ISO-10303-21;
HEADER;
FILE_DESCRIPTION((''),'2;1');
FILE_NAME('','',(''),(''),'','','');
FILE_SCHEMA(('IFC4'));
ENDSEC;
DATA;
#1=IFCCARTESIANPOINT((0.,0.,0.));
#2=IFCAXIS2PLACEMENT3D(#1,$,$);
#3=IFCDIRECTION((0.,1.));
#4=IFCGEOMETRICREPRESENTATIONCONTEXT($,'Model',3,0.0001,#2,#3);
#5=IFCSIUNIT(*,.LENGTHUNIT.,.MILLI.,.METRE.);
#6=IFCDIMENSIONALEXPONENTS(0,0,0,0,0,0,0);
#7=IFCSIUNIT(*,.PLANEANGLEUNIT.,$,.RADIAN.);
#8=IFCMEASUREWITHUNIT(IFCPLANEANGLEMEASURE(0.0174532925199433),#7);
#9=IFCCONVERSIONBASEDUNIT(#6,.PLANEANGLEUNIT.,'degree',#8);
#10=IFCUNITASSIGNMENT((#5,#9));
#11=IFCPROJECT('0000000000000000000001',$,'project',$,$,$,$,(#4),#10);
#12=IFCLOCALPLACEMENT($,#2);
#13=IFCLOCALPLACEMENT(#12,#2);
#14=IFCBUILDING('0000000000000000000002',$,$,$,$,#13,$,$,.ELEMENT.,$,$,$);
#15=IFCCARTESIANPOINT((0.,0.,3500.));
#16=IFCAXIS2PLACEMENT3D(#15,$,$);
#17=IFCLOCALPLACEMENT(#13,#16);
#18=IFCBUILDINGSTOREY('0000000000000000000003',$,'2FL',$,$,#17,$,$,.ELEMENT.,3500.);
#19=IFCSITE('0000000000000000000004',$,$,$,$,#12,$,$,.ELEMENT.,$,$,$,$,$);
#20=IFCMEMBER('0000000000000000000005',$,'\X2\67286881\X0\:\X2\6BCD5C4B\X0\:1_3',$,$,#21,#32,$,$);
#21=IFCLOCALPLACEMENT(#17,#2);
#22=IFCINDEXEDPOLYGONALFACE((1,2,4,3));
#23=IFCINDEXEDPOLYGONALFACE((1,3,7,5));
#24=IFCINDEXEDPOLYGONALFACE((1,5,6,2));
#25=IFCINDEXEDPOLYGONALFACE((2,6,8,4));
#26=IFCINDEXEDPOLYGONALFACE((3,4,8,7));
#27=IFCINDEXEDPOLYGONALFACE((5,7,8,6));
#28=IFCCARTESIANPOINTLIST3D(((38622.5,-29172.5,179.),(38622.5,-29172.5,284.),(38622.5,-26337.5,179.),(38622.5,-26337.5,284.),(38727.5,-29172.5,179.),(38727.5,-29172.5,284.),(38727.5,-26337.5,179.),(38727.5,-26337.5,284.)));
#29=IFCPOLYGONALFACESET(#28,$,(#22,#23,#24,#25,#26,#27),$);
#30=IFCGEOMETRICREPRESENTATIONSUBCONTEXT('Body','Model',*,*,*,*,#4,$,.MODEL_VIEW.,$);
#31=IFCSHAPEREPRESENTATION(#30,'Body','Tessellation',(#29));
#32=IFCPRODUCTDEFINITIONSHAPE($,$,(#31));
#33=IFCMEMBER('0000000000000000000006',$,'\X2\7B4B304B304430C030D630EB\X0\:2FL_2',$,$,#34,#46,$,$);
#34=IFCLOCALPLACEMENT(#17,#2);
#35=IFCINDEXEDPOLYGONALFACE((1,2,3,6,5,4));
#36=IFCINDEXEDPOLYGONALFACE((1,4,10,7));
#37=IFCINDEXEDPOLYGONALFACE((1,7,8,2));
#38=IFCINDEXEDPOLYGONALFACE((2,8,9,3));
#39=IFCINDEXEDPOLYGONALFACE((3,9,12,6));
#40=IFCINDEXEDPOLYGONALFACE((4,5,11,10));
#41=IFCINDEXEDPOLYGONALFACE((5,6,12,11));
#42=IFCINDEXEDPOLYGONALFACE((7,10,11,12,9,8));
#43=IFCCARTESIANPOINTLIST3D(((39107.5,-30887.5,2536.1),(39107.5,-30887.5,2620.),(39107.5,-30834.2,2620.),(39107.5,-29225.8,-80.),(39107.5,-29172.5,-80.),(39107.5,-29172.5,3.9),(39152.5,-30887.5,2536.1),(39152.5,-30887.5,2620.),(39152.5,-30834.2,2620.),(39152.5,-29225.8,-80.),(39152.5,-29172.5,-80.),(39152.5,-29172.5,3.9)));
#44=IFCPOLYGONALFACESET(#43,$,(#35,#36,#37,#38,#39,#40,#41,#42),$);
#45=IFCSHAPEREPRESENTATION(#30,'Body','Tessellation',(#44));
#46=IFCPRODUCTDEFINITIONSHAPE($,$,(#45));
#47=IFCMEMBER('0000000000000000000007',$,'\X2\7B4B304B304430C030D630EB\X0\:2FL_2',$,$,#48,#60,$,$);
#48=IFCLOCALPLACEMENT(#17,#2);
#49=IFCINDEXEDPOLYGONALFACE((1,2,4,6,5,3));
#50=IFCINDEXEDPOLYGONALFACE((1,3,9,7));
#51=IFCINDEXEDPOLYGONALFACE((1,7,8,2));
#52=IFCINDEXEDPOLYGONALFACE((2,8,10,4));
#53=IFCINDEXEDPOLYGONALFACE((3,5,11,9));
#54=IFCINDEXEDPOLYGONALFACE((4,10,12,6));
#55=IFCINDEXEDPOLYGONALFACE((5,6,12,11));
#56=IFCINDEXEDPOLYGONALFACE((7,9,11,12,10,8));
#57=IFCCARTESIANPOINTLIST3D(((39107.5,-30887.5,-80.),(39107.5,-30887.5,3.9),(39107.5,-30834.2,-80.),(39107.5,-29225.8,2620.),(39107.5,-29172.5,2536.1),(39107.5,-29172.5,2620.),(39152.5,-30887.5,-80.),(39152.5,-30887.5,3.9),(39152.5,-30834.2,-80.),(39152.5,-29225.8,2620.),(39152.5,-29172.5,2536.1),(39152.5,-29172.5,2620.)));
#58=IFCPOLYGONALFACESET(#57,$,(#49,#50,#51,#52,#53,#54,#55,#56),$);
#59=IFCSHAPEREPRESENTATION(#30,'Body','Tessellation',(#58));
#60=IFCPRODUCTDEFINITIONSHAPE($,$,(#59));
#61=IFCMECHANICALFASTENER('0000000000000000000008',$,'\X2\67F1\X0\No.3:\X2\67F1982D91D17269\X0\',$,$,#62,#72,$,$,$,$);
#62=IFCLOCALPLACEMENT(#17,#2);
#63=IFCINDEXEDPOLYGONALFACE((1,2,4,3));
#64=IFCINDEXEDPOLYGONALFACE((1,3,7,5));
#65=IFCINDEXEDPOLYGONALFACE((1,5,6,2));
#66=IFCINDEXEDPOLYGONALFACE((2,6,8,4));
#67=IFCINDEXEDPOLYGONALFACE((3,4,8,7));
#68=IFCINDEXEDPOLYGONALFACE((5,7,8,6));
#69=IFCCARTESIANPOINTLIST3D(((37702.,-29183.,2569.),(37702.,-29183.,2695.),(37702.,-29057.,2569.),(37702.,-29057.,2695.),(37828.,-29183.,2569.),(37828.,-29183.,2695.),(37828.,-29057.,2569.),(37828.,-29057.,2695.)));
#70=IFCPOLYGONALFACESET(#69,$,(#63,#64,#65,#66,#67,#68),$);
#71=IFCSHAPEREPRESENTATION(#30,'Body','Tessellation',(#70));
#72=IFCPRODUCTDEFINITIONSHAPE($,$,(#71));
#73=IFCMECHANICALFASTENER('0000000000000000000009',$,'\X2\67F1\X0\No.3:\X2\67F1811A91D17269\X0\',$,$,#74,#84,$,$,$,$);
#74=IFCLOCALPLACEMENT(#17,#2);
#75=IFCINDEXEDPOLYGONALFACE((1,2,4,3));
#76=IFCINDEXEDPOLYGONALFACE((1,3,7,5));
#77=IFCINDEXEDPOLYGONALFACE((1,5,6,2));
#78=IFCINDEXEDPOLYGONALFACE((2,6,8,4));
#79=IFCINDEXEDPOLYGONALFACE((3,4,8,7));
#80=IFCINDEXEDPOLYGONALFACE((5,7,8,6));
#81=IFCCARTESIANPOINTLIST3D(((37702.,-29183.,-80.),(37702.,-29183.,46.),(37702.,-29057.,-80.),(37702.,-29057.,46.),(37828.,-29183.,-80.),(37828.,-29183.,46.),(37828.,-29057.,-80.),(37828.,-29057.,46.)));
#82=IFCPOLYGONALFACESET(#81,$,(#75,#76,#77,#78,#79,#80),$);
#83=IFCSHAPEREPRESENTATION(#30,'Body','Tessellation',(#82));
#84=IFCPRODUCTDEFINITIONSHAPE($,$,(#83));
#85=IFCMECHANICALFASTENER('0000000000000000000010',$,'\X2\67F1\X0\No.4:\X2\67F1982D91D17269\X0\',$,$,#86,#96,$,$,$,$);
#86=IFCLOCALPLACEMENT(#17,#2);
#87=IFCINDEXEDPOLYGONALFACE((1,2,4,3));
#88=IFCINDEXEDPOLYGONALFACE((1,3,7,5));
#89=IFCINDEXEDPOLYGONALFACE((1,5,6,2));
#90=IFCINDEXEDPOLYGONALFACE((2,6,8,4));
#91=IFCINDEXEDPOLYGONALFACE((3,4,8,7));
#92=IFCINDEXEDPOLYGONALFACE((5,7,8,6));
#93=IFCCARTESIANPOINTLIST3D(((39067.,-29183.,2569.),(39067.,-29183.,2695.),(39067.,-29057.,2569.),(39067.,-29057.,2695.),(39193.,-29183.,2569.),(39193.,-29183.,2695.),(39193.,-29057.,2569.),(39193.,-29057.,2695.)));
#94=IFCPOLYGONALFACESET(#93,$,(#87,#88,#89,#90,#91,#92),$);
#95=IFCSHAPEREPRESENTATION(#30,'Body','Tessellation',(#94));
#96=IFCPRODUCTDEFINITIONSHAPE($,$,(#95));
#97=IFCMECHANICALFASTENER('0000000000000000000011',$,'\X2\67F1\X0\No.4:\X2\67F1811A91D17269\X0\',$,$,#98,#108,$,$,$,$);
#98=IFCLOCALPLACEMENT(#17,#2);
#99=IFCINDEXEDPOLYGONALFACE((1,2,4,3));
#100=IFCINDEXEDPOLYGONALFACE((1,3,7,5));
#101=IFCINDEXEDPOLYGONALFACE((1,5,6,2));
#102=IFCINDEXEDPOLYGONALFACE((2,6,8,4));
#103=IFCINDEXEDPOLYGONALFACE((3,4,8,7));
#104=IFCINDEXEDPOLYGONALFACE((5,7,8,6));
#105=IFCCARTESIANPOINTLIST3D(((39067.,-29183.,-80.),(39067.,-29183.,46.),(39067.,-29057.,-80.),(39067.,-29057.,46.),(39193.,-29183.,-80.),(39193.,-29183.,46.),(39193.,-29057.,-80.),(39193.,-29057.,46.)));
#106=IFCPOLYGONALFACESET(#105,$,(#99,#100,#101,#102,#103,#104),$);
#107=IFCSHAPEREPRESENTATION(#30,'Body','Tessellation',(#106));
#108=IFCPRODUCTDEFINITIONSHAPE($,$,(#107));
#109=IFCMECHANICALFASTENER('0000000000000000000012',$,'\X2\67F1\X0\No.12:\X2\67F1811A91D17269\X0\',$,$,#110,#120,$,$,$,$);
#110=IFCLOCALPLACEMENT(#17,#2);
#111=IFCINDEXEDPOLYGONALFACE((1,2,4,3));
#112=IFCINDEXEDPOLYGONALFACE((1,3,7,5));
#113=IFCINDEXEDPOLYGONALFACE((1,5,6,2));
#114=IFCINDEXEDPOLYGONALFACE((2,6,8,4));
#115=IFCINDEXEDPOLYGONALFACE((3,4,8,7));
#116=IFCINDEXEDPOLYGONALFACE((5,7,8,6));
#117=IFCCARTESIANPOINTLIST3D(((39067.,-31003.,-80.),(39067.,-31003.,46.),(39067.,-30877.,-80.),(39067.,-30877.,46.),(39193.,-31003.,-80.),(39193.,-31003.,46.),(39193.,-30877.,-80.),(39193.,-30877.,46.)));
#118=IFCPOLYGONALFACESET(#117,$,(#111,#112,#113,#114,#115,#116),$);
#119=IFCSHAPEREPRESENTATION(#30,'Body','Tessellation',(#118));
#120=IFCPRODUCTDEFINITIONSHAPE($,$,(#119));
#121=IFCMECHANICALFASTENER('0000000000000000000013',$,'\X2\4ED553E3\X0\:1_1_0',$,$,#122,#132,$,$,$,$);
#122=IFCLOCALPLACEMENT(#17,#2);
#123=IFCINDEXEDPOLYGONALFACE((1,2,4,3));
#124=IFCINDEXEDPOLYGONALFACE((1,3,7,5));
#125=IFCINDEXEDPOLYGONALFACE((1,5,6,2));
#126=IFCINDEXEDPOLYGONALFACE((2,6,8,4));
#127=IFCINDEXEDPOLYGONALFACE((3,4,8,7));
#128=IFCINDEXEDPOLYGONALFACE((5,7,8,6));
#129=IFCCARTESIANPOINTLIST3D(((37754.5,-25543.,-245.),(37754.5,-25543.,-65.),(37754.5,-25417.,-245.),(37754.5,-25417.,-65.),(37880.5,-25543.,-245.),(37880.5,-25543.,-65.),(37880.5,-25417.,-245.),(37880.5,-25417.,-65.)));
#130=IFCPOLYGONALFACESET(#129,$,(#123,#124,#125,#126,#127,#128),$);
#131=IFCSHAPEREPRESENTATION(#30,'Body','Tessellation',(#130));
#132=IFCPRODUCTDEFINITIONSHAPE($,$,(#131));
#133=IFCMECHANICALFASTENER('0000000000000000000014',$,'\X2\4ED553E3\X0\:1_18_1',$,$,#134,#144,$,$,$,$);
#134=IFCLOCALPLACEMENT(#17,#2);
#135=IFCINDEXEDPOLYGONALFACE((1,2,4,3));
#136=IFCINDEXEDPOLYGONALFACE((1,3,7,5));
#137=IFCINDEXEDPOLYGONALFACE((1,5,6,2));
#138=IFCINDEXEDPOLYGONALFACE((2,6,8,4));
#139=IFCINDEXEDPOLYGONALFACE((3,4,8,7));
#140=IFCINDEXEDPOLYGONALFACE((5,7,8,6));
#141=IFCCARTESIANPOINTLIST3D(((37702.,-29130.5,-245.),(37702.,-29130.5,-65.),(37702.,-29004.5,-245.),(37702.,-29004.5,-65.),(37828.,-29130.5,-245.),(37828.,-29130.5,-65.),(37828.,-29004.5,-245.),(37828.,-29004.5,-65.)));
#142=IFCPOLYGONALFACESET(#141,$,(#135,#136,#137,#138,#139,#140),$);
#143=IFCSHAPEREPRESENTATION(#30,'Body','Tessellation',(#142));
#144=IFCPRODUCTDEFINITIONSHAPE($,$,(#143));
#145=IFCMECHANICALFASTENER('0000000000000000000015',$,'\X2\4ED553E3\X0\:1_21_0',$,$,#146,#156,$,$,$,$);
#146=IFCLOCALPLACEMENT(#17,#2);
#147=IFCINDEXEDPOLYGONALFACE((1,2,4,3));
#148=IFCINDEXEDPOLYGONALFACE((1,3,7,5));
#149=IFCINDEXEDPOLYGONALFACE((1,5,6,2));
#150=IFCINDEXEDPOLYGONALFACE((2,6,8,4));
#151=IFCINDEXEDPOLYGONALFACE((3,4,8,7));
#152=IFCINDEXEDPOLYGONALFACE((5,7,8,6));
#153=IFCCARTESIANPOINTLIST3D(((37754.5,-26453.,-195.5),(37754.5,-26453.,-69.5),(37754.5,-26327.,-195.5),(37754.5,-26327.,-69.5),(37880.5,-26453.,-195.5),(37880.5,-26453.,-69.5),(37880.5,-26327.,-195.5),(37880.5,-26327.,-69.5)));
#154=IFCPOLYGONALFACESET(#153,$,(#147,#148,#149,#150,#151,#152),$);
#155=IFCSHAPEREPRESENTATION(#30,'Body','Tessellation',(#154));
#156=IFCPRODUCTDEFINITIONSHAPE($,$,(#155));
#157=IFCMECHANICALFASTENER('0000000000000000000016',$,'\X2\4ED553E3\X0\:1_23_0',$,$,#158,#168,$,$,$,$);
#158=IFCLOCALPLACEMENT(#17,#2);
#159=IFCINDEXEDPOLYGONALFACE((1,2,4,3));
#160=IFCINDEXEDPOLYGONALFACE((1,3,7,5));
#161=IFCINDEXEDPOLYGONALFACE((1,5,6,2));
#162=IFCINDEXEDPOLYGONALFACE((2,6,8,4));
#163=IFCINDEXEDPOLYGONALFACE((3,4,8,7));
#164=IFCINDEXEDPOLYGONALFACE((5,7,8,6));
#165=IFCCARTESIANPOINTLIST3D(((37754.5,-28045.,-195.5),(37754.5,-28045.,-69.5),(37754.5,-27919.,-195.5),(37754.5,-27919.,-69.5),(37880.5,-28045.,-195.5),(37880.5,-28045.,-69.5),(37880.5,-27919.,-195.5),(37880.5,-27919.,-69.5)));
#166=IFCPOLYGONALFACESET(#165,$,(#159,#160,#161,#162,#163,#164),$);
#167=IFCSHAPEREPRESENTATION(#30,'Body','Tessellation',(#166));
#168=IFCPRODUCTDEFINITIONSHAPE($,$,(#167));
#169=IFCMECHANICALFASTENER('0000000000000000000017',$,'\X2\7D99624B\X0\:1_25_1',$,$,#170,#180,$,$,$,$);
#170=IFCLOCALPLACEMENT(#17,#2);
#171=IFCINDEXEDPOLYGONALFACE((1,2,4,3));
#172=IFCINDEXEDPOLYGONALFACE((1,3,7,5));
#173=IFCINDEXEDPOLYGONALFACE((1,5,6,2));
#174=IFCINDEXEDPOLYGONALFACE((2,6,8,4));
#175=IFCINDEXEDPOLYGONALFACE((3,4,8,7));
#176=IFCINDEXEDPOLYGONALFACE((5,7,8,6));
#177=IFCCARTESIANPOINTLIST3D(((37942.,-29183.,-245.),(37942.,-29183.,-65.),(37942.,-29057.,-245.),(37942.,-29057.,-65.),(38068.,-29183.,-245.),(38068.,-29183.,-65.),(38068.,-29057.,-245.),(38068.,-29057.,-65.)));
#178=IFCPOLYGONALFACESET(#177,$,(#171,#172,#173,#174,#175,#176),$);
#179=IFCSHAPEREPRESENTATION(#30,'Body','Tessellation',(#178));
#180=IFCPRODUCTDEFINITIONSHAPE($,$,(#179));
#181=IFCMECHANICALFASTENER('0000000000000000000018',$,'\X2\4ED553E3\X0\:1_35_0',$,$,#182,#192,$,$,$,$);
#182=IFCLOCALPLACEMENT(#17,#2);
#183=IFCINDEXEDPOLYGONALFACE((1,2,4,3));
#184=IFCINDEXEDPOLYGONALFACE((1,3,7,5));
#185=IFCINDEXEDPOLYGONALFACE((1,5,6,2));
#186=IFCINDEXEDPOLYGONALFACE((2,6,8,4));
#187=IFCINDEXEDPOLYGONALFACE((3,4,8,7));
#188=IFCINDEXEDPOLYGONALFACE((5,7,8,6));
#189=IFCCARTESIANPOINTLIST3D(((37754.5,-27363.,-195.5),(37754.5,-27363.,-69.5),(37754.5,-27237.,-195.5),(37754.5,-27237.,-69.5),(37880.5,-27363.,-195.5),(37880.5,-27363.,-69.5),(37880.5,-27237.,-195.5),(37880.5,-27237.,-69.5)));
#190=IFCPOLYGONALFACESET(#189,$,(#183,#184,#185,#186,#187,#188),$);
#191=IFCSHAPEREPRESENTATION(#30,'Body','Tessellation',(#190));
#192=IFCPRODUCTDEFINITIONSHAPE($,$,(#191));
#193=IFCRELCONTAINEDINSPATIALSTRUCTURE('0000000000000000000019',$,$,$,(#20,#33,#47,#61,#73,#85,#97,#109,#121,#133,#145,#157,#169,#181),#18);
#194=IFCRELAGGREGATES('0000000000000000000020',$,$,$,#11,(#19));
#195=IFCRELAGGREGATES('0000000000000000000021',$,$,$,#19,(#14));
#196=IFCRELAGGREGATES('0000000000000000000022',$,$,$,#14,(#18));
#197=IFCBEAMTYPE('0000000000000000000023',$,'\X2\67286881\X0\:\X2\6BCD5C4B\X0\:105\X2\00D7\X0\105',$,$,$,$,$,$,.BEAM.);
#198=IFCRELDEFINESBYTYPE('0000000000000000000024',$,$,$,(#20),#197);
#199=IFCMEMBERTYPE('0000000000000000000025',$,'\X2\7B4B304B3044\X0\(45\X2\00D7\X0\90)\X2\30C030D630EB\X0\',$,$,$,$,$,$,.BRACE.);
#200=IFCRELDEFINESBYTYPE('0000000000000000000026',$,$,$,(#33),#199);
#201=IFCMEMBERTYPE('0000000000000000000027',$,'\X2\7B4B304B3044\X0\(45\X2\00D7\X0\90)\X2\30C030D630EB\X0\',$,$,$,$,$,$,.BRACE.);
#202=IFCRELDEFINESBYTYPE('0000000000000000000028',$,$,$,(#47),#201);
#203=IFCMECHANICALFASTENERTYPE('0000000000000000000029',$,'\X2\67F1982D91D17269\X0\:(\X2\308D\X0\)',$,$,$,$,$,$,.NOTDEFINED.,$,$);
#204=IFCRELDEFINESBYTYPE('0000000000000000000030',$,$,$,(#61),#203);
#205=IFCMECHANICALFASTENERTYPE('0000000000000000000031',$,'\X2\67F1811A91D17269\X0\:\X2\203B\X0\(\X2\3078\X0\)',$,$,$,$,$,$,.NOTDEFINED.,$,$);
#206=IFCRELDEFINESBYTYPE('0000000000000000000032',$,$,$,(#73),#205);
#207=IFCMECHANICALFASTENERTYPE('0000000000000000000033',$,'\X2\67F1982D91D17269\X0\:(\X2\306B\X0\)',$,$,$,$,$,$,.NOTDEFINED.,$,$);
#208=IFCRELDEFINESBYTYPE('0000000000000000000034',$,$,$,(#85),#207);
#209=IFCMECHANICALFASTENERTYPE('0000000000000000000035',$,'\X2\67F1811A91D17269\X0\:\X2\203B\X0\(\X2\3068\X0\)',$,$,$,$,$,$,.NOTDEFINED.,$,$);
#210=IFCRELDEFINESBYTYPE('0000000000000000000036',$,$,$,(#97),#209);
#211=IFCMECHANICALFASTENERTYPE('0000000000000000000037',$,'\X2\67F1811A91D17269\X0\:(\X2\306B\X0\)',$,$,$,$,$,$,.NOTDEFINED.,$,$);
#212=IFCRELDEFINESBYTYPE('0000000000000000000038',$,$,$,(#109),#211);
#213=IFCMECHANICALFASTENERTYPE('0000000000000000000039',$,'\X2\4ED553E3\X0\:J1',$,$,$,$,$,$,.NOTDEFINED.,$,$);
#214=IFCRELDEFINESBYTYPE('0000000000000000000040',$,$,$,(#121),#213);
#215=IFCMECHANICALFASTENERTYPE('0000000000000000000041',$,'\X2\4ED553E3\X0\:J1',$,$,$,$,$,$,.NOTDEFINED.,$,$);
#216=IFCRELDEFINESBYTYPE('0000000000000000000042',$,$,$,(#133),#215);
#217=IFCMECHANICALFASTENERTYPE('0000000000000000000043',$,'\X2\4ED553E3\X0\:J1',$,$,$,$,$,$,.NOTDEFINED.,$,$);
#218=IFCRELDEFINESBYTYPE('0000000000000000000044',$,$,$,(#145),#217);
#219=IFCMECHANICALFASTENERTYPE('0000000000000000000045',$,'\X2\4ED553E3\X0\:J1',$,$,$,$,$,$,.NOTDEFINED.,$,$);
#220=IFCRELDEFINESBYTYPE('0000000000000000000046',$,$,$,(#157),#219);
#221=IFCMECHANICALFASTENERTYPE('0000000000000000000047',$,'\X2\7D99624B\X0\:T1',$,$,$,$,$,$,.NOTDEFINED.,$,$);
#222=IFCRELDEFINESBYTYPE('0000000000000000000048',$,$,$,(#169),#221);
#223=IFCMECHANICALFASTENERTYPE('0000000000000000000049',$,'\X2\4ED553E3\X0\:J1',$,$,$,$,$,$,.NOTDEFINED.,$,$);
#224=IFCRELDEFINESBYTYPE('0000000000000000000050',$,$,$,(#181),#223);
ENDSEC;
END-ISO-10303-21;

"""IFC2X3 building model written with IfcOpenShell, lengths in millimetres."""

from ifc_helpers import new_model, entity, si_unit, converted_unit, direction, frame, origin, origin_with_axes, origin_2d, place, context, subcontext, project, spatial, polyline, rectangle, outline, extrude, type_object, element, save


model = new_model("IFC2X3")

# Units and contexts
model_context = context("Model", 3, precision=0.0001, world=origin(), true_north=direction((0.0, 1.0)))
body_context = subcontext(model_context, "Body", "Model", "MODEL_VIEW")
ifc_project = project(units=[si_unit("LENGTHUNIT", "METRE", prefix="MILLI"), converted_unit("PLANEANGLEUNIT", "degree", entity("IfcPlaneAngleMeasure", 0.0174532925199433), si_unit("PLANEANGLEUNIT", "RADIAN"), dimensions=[0, 0, 0, 0, 0, 0, 0])], contexts=[model_context])

# Site, building, storey
site_placement = place(None, origin())
site = spatial("IfcSite", under=ifc_project, at=site_placement, CompositionType="ELEMENT")
building_placement = place(site_placement, origin())
building = spatial("IfcBuilding", under=site, at=building_placement, CompositionType="ELEMENT")
storey_placement = place(building_placement, frame((0.0, 0.0, 3500.0)))
storey = spatial("IfcBuildingStorey", under=building, at=storey_placement, Name="2FL", CompositionType="ELEMENT", Elevation=3500.0)

# Members
beam_type_1 = type_object("IfcBeamType", Name="木梁:母屋:105×105", PredefinedType="BEAM")
member_1_placement = place(storey_placement, frame((38675.0, -26337.5, 231.5), z_axis=(0.0, -1.0, 0.0), x_axis=(-1.0, 0.0, 0.0)))
element("IfcMember", 1, at=member_1_placement, inside=storey, type_object=beam_type_1, Name="木梁:母屋:1_3", context=body_context, shape_type="SweptSolid", body=[
    extrude(rectangle(XDim=105.0, YDim=105.0, at=origin_2d()), origin_with_axes(), (0.0, 0.0, 1.0), 2835.0),
])
member_type_1 = type_object("IfcMemberType", Name="筋かい(45×90)ダブル", PredefinedType="BRACE")
member_2_placement = place(storey_placement, frame((39130.0, -29172.5, -80.0), z_axis=(0.0, -0.536167, 0.844112), x_axis=(0.0, 0.844112, 0.536167)))
element("IfcMember", 2, at=member_2_placement, inside=storey, type_object=member_type_1, Name="筋かいダブル:2FL_2", context=body_context, shape_type="SweptSolid", body=[
    extrude(outline(polyline([(0.0, 0.0), (28.6, -45.0), (3127.8, -45.0), (3198.6, 0.0), (3170.0, 45.0), (70.8, 45.0), (0.0, 0.0)])), frame((0.0, -22.5, 0.0), z_axis=(0.0, 1.0, 0.0), x_axis=(0.0, 0.0, 1.0)), (0.0, 0.0, 1.0), 45.0),
])
member_type_2 = type_object("IfcMemberType", Name="筋かい(45×90)ダブル", PredefinedType="BRACE")
member_3_placement = place(storey_placement, frame((39130.0, -30887.5, -80.0), z_axis=(0.0, 0.536167, 0.844112), x_axis=(0.0, -0.844112, 0.536167)))
element("IfcMember", 3, at=member_3_placement, inside=storey, type_object=member_type_2, Name="筋かいダブル:2FL_2", context=body_context, shape_type="SweptSolid", body=[
    extrude(outline(polyline([(0.0, 0.0), (28.6, -45.0), (3127.8, -45.0), (3198.6, 0.0), (3170.0, 45.0), (70.8, 45.0), (0.0, 0.0)])), frame((0.0, -22.5, 0.0), z_axis=(0.0, 1.0, 0.0), x_axis=(0.0, 0.0, 1.0)), (0.0, 0.0, 1.0), 45.0),
])

# Mechanical fasteners
mechanical_fastener_type_1 = type_object("IfcMechanicalFastenerType", Name="柱頭金物:(ろ)")
mechanical_fastener_1_placement = place(storey_placement, frame((37765.0, -29120.0, 2569.0)))
element("IfcMechanicalFastener", 4, at=mechanical_fastener_1_placement, inside=storey, type_object=mechanical_fastener_type_1, Name="柱No.3:柱頭金物", context=body_context, shape_type="SweptSolid", body=[
    extrude(rectangle(XDim=126.0, YDim=126.0, at=origin_2d()), origin_with_axes(), (0.0, 0.0, 1.0), 126.0),
])
mechanical_fastener_type_2 = type_object("IfcMechanicalFastenerType", Name="柱脚金物:※(へ)")
mechanical_fastener_2_placement = place(storey_placement, frame((37765.0, -29120.0, -80.0)))
element("IfcMechanicalFastener", 5, at=mechanical_fastener_2_placement, inside=storey, type_object=mechanical_fastener_type_2, Name="柱No.3:柱脚金物", context=body_context, shape_type="SweptSolid", body=[
    extrude(rectangle(XDim=126.0, YDim=126.0, at=origin_2d()), origin_with_axes(), (0.0, 0.0, 1.0), 126.0),
])
mechanical_fastener_type_3 = type_object("IfcMechanicalFastenerType", Name="柱頭金物:(に)")
mechanical_fastener_3_placement = place(storey_placement, frame((39130.0, -29120.0, 2569.0)))
element("IfcMechanicalFastener", 6, at=mechanical_fastener_3_placement, inside=storey, type_object=mechanical_fastener_type_3, Name="柱No.4:柱頭金物", context=body_context, shape_type="SweptSolid", body=[
    extrude(rectangle(XDim=126.0, YDim=126.0, at=origin_2d()), origin_with_axes(), (0.0, 0.0, 1.0), 126.0),
])
mechanical_fastener_type_4 = type_object("IfcMechanicalFastenerType", Name="柱脚金物:※(と)")
mechanical_fastener_4_placement = place(storey_placement, frame((39130.0, -29120.0, -80.0)))
element("IfcMechanicalFastener", 7, at=mechanical_fastener_4_placement, inside=storey, type_object=mechanical_fastener_type_4, Name="柱No.4:柱脚金物", context=body_context, shape_type="SweptSolid", body=[
    extrude(rectangle(XDim=126.0, YDim=126.0, at=origin_2d()), origin_with_axes(), (0.0, 0.0, 1.0), 126.0),
])
mechanical_fastener_type_5 = type_object("IfcMechanicalFastenerType", Name="柱脚金物:(に)")
mechanical_fastener_5_placement = place(storey_placement, frame((39130.0, -30940.0, -80.0)))
element("IfcMechanicalFastener", 8, at=mechanical_fastener_5_placement, inside=storey, type_object=mechanical_fastener_type_5, Name="柱No.12:柱脚金物", context=body_context, shape_type="SweptSolid", body=[
    extrude(rectangle(XDim=126.0, YDim=126.0, at=origin_2d()), origin_with_axes(), (0.0, 0.0, 1.0), 126.0),
])
mechanical_fastener_type_6 = type_object("IfcMechanicalFastenerType", Name="仕口:J1")
mechanical_fastener_6_placement = place(storey_placement, frame((37817.5, -25480.0, -245.0)))
element("IfcMechanicalFastener", 9, at=mechanical_fastener_6_placement, inside=storey, type_object=mechanical_fastener_type_6, Name="仕口:1_1_0", context=body_context, shape_type="SweptSolid", body=[
    extrude(rectangle(XDim=126.0, YDim=126.0, at=origin_2d()), origin_with_axes(), (0.0, 0.0, 1.0), 180.0),
])
mechanical_fastener_type_7 = type_object("IfcMechanicalFastenerType", Name="仕口:J1")
mechanical_fastener_7_placement = place(storey_placement, frame((37765.0, -29067.5, -245.0)))
element("IfcMechanicalFastener", 10, at=mechanical_fastener_7_placement, inside=storey, type_object=mechanical_fastener_type_7, Name="仕口:1_18_1", context=body_context, shape_type="SweptSolid", body=[
    extrude(rectangle(XDim=126.0, YDim=126.0, at=origin_2d()), origin_with_axes(), (0.0, 0.0, 1.0), 180.0),
])
mechanical_fastener_type_8 = type_object("IfcMechanicalFastenerType", Name="仕口:J1")
mechanical_fastener_8_placement = place(storey_placement, frame((37817.5, -26390.0, -195.5)))
element("IfcMechanicalFastener", 11, at=mechanical_fastener_8_placement, inside=storey, type_object=mechanical_fastener_type_8, Name="仕口:1_21_0", context=body_context, shape_type="SweptSolid", body=[
    extrude(rectangle(XDim=126.0, YDim=126.0, at=origin_2d()), origin_with_axes(), (0.0, 0.0, 1.0), 126.0),
])
mechanical_fastener_type_9 = type_object("IfcMechanicalFastenerType", Name="仕口:J1")
mechanical_fastener_9_placement = place(storey_placement, frame((37817.5, -27982.0, -195.5)))
element("IfcMechanicalFastener", 12, at=mechanical_fastener_9_placement, inside=storey, type_object=mechanical_fastener_type_9, Name="仕口:1_23_0", context=body_context, shape_type="SweptSolid", body=[
    extrude(rectangle(XDim=126.0, YDim=126.0, at=origin_2d()), origin_with_axes(), (0.0, 0.0, 1.0), 126.0),
])
mechanical_fastener_type_10 = type_object("IfcMechanicalFastenerType", Name="継手:T1")
mechanical_fastener_10_placement = place(storey_placement, frame((38005.0, -29120.0, -245.0)))
element("IfcMechanicalFastener", 13, at=mechanical_fastener_10_placement, inside=storey, type_object=mechanical_fastener_type_10, Name="継手:1_25_1", context=body_context, shape_type="SweptSolid", body=[
    extrude(rectangle(XDim=126.0, YDim=126.0, at=origin_2d()), origin_with_axes(), (0.0, 0.0, 1.0), 180.0),
])
mechanical_fastener_type_11 = type_object("IfcMechanicalFastenerType", Name="仕口:J1")
mechanical_fastener_11_placement = place(storey_placement, frame((37817.5, -27300.0, -195.5)))
element("IfcMechanicalFastener", 14, at=mechanical_fastener_11_placement, inside=storey, type_object=mechanical_fastener_type_11, Name="仕口:1_35_0", context=body_context, shape_type="SweptSolid", body=[
    extrude(rectangle(XDim=126.0, YDim=126.0, at=origin_2d()), origin_with_axes(), (0.0, 0.0, 1.0), 126.0),
])

save(model, "model.ifc")
